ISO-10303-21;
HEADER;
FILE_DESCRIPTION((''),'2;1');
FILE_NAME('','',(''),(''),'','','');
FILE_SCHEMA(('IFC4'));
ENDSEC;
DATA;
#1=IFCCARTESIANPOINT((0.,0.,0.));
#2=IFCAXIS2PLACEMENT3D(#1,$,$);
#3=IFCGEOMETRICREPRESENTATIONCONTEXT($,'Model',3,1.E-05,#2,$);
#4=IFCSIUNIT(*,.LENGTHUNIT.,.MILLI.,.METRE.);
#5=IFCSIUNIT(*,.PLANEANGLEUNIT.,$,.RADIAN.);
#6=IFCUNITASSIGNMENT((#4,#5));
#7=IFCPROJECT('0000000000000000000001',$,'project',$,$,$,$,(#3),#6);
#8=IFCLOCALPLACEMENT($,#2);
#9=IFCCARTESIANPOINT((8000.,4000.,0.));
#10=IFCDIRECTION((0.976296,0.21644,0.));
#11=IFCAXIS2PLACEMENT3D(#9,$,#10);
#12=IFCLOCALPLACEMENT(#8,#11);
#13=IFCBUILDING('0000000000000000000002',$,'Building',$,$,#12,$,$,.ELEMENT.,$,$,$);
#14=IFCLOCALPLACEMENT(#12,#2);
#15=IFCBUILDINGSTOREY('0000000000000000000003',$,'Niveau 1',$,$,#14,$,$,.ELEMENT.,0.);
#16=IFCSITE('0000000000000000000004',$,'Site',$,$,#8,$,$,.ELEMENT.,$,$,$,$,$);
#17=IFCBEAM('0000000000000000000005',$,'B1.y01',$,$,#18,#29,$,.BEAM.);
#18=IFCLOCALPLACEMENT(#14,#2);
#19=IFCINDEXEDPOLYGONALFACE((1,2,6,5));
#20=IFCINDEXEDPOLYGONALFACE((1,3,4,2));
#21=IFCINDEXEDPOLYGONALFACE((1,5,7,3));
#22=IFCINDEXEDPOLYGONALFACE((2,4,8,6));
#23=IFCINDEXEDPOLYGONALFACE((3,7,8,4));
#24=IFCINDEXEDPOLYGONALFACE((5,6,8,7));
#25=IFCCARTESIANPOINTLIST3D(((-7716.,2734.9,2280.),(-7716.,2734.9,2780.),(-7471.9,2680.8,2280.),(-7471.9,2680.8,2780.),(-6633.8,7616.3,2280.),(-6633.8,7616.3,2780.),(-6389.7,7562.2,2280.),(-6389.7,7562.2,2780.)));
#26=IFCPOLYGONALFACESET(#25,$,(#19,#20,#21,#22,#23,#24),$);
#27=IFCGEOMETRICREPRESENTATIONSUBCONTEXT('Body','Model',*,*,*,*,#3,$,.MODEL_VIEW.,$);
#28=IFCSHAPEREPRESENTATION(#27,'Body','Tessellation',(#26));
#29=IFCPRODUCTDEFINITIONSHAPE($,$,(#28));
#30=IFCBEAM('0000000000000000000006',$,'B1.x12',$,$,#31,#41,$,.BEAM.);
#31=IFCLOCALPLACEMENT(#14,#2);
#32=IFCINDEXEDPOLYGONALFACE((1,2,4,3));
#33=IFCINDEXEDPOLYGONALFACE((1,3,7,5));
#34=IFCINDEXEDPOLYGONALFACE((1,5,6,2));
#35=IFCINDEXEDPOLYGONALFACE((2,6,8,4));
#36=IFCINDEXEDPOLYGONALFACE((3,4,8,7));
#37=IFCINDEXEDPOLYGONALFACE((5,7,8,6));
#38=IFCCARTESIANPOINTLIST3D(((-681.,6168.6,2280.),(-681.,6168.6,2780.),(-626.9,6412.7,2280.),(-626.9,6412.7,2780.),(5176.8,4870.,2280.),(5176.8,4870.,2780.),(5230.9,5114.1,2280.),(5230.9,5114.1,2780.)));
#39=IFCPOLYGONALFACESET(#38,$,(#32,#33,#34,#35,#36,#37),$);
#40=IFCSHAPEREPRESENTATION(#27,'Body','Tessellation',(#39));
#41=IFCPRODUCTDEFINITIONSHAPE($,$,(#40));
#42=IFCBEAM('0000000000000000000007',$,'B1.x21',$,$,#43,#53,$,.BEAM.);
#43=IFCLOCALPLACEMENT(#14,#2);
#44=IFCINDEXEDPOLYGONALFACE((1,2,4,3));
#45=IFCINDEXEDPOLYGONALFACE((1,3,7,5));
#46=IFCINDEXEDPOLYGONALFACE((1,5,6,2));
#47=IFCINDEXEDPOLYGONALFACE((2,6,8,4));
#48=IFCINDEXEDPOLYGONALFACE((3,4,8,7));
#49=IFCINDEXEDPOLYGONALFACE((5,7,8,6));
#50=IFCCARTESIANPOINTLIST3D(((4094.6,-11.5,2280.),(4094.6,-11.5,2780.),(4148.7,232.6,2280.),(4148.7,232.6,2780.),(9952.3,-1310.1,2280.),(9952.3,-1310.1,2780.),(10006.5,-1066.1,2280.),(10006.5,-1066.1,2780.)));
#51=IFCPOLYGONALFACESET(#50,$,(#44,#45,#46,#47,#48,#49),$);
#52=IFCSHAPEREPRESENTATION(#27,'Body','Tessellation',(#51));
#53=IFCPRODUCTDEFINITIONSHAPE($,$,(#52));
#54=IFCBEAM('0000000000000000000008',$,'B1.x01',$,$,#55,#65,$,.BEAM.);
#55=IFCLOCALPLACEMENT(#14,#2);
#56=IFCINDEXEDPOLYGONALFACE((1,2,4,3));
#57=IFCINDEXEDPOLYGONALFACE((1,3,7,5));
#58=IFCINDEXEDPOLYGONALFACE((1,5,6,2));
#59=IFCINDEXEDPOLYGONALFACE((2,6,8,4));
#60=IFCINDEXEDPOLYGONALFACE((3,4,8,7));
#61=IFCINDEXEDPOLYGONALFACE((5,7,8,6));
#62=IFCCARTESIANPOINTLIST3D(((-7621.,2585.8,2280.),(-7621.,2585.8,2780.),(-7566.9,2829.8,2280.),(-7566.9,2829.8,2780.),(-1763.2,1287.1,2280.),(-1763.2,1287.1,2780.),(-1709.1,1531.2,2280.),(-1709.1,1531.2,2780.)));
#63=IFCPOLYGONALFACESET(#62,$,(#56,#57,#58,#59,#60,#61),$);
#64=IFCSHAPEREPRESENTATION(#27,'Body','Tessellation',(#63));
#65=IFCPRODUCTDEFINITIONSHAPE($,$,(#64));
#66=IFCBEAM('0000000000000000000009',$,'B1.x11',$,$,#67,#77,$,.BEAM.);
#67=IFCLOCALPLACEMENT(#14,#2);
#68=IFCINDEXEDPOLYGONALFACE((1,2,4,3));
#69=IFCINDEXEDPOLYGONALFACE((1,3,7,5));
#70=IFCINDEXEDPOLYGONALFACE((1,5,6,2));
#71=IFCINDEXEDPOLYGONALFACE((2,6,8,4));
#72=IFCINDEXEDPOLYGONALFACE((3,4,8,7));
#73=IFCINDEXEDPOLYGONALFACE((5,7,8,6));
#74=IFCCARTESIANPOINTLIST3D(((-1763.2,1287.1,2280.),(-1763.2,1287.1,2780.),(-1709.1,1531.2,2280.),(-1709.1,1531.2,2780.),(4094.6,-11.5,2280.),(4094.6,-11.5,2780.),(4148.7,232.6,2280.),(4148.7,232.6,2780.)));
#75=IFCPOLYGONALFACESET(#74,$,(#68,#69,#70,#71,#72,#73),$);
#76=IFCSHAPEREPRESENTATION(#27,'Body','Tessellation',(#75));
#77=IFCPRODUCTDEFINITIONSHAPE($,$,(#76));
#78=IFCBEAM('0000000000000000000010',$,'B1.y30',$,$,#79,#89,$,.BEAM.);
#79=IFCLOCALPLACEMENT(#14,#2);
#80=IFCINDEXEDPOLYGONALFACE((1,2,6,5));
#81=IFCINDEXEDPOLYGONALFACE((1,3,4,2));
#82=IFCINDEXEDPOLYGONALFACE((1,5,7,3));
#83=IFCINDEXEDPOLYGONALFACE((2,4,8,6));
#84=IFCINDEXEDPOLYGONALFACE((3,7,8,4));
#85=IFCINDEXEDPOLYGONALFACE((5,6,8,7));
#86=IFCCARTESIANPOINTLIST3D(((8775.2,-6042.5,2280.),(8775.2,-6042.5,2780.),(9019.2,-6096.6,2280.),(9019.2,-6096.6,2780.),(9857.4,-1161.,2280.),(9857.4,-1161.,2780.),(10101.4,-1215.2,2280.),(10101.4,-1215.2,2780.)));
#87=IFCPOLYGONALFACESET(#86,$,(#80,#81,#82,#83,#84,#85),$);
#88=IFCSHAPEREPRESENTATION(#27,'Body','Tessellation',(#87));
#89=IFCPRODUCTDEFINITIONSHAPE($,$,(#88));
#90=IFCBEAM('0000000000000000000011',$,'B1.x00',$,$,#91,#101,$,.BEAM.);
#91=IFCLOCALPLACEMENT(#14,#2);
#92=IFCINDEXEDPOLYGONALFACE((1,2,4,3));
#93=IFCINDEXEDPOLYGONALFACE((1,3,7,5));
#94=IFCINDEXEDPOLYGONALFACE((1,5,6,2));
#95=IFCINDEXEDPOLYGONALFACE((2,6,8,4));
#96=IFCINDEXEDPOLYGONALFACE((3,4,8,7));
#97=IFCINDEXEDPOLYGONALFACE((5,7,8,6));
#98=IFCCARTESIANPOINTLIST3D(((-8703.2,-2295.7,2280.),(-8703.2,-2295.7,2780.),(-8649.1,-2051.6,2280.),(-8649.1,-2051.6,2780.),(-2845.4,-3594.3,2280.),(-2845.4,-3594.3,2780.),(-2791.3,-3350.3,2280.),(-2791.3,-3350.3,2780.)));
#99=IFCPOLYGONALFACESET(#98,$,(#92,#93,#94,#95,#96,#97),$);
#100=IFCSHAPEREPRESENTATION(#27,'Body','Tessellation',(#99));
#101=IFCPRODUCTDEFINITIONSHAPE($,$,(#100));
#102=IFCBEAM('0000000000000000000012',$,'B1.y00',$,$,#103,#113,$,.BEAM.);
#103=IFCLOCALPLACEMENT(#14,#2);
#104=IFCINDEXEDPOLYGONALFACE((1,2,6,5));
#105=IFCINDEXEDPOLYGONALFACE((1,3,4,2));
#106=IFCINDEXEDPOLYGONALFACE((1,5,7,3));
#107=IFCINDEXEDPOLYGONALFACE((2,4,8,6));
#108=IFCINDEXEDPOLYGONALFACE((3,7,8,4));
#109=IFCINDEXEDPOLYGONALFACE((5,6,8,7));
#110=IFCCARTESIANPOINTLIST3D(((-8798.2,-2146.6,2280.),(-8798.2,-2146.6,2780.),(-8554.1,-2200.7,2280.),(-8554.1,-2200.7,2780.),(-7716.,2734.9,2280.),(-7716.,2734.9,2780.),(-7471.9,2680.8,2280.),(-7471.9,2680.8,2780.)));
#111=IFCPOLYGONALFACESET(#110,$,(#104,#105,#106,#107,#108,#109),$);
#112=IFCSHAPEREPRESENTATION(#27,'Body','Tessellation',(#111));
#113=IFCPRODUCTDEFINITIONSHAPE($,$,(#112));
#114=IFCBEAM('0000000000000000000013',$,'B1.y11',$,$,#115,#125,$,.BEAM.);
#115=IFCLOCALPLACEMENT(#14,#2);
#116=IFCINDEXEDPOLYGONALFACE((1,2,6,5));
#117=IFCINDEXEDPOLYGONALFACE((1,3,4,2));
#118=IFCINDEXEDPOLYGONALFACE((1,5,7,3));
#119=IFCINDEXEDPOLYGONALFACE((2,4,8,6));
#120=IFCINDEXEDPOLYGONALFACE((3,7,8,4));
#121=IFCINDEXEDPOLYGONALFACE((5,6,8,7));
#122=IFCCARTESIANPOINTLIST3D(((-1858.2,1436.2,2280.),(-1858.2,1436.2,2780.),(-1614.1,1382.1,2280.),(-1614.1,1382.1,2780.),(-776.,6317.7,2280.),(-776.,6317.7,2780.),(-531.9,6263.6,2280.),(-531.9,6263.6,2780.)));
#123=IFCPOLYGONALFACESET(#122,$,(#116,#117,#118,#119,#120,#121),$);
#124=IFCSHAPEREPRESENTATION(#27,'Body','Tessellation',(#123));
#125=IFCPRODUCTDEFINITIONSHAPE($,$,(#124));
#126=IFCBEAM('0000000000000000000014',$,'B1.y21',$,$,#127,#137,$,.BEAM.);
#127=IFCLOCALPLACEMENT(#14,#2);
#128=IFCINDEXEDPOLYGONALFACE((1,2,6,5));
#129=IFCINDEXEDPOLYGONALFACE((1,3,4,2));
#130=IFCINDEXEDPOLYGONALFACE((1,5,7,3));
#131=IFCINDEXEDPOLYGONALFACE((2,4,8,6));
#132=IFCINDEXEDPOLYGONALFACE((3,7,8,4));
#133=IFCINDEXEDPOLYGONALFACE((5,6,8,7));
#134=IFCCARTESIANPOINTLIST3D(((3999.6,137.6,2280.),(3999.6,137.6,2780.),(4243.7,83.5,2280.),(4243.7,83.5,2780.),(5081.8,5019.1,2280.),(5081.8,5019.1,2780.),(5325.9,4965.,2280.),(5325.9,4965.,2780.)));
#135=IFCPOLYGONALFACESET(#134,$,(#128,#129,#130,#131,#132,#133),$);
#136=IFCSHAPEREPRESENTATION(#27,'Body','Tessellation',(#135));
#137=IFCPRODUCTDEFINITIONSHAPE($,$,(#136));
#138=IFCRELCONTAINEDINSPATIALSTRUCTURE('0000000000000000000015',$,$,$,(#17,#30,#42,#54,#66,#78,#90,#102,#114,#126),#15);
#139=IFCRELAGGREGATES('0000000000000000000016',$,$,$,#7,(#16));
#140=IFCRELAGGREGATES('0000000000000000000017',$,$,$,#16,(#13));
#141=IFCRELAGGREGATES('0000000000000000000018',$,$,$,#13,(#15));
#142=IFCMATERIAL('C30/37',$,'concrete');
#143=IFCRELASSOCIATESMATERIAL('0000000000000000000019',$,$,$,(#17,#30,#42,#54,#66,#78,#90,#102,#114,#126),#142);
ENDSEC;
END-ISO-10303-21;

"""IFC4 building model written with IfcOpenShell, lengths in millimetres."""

from ifc_helpers import new_model, si_unit, frame, origin, place, context, subcontext, project, spatial, rectangle, extrude, material, element, save


model = new_model("IFC4")

# Units and contexts
model_context = context("Model", 3, precision=1e-05, world=origin())
body_context = subcontext(model_context, "Body", "Model", "MODEL_VIEW")
ifc_project = project(units=[si_unit("LENGTHUNIT", "METRE", prefix="MILLI"), si_unit("PLANEANGLEUNIT", "RADIAN")], contexts=[model_context])

# Site, building, storey
site_placement = place(None, origin())
site = spatial("IfcSite", under=ifc_project, at=site_placement, Name="Site", CompositionType="ELEMENT")
building_placement = place(site_placement, frame((8000.0, 4000.0, 0.0), x_axis=(0.976296, 0.21644, 0.0)))
building = spatial("IfcBuilding", under=site, at=building_placement, Name="Building", CompositionType="ELEMENT")
storey_placement = place(building_placement, origin())
storey = spatial("IfcBuildingStorey", under=building, at=storey_placement, Name="Niveau 1", CompositionType="ELEMENT", Elevation=0.0)

# Shared definitions
ifc_material = material(Name="C30/37", Category="concrete")

# Beams
beam_1_placement = place(storey_placement, frame((-7593.9, 2707.8, 2530.0), z_axis=(0.21644, 0.976296, 0.0), x_axis=(-0.976296, 0.21644, 0.0)))
element("IfcBeam", 1, at=beam_1_placement, inside=storey, material=ifc_material, Name="B1.y01", PredefinedType="BEAM", context=body_context, shape_type="SweptSolid", body=[
    extrude(rectangle(XDim=250.0, YDim=500.0), origin(), (0.0, 0.0, 1.0), 5000.0),
])
for number, where, z_axis, x_axis, name in (
    (2, (-654.0, 6290.7, 2530.0), (0.976296, -0.21644, 0.0), (0.21644, 0.976296, 0.0), "B1.x12"),
    (3, (4121.6, 110.5, 2530.0), (0.976296, -0.21644, 0.0), (0.21644, 0.976296, 0.0), "B1.x21"),
    (4, (-7593.9, 2707.8, 2530.0), (0.976296, -0.21644, 0.0), (0.21644, 0.976296, 0.0), "B1.x01"),
    (5, (-1736.2, 1409.2, 2530.0), (0.976296, -0.21644, 0.0), (0.21644, 0.976296, 0.0), "B1.x11"),
):
    element("IfcBeam", number, at=place(storey_placement, frame(where, z_axis=z_axis, x_axis=x_axis)), inside=storey, material=ifc_material, Name=name, PredefinedType="BEAM", context=body_context, shape_type="SweptSolid", body=[
        extrude(rectangle(XDim=250.0, YDim=500.0), origin(), (0.0, 0.0, 1.0), 6000.0),
    ])
beam_2_placement = place(storey_placement, frame((8897.2, -6069.6, 2530.0), z_axis=(0.21644, 0.976296, 0.0), x_axis=(-0.976296, 0.21644, 0.0)))
element("IfcBeam", 6, at=beam_2_placement, inside=storey, material=ifc_material, Name="B1.y30", PredefinedType="BEAM", context=body_context, shape_type="SweptSolid", body=[
    extrude(rectangle(XDim=250.0, YDim=500.0), origin(), (0.0, 0.0, 1.0), 5000.0),
])
beam_3_placement = place(storey_placement, frame((-8676.1, -2173.7, 2530.0), z_axis=(0.976296, -0.21644, 0.0), x_axis=(0.21644, 0.976296, 0.0)))
element("IfcBeam", 7, at=beam_3_placement, inside=storey, material=ifc_material, Name="B1.x00", PredefinedType="BEAM", context=body_context, shape_type="SweptSolid", body=[
    extrude(rectangle(XDim=250.0, YDim=500.0), origin(), (0.0, 0.0, 1.0), 6000.0),
])
for number, where, z_axis, x_axis, name in (
    (8, (-8676.1, -2173.7, 2530.0), (0.21644, 0.976296, 0.0), (-0.976296, 0.21644, 0.0), "B1.y00"),
    (9, (-1736.2, 1409.2, 2530.0), (0.21644, 0.976296, 0.0), (-0.976296, 0.21644, 0.0), "B1.y11"),
    (10, (4121.6, 110.5, 2530.0), (0.21644, 0.976296, 0.0), (-0.976296, 0.21644, 0.0), "B1.y21"),
):
    element("IfcBeam", number, at=place(storey_placement, frame(where, z_axis=z_axis, x_axis=x_axis)), inside=storey, material=ifc_material, Name=name, PredefinedType="BEAM", context=body_context, shape_type="SweptSolid", body=[
        extrude(rectangle(XDim=250.0, YDim=500.0), origin(), (0.0, 0.0, 1.0), 5000.0),
    ])

save(model, "model.ifc")
